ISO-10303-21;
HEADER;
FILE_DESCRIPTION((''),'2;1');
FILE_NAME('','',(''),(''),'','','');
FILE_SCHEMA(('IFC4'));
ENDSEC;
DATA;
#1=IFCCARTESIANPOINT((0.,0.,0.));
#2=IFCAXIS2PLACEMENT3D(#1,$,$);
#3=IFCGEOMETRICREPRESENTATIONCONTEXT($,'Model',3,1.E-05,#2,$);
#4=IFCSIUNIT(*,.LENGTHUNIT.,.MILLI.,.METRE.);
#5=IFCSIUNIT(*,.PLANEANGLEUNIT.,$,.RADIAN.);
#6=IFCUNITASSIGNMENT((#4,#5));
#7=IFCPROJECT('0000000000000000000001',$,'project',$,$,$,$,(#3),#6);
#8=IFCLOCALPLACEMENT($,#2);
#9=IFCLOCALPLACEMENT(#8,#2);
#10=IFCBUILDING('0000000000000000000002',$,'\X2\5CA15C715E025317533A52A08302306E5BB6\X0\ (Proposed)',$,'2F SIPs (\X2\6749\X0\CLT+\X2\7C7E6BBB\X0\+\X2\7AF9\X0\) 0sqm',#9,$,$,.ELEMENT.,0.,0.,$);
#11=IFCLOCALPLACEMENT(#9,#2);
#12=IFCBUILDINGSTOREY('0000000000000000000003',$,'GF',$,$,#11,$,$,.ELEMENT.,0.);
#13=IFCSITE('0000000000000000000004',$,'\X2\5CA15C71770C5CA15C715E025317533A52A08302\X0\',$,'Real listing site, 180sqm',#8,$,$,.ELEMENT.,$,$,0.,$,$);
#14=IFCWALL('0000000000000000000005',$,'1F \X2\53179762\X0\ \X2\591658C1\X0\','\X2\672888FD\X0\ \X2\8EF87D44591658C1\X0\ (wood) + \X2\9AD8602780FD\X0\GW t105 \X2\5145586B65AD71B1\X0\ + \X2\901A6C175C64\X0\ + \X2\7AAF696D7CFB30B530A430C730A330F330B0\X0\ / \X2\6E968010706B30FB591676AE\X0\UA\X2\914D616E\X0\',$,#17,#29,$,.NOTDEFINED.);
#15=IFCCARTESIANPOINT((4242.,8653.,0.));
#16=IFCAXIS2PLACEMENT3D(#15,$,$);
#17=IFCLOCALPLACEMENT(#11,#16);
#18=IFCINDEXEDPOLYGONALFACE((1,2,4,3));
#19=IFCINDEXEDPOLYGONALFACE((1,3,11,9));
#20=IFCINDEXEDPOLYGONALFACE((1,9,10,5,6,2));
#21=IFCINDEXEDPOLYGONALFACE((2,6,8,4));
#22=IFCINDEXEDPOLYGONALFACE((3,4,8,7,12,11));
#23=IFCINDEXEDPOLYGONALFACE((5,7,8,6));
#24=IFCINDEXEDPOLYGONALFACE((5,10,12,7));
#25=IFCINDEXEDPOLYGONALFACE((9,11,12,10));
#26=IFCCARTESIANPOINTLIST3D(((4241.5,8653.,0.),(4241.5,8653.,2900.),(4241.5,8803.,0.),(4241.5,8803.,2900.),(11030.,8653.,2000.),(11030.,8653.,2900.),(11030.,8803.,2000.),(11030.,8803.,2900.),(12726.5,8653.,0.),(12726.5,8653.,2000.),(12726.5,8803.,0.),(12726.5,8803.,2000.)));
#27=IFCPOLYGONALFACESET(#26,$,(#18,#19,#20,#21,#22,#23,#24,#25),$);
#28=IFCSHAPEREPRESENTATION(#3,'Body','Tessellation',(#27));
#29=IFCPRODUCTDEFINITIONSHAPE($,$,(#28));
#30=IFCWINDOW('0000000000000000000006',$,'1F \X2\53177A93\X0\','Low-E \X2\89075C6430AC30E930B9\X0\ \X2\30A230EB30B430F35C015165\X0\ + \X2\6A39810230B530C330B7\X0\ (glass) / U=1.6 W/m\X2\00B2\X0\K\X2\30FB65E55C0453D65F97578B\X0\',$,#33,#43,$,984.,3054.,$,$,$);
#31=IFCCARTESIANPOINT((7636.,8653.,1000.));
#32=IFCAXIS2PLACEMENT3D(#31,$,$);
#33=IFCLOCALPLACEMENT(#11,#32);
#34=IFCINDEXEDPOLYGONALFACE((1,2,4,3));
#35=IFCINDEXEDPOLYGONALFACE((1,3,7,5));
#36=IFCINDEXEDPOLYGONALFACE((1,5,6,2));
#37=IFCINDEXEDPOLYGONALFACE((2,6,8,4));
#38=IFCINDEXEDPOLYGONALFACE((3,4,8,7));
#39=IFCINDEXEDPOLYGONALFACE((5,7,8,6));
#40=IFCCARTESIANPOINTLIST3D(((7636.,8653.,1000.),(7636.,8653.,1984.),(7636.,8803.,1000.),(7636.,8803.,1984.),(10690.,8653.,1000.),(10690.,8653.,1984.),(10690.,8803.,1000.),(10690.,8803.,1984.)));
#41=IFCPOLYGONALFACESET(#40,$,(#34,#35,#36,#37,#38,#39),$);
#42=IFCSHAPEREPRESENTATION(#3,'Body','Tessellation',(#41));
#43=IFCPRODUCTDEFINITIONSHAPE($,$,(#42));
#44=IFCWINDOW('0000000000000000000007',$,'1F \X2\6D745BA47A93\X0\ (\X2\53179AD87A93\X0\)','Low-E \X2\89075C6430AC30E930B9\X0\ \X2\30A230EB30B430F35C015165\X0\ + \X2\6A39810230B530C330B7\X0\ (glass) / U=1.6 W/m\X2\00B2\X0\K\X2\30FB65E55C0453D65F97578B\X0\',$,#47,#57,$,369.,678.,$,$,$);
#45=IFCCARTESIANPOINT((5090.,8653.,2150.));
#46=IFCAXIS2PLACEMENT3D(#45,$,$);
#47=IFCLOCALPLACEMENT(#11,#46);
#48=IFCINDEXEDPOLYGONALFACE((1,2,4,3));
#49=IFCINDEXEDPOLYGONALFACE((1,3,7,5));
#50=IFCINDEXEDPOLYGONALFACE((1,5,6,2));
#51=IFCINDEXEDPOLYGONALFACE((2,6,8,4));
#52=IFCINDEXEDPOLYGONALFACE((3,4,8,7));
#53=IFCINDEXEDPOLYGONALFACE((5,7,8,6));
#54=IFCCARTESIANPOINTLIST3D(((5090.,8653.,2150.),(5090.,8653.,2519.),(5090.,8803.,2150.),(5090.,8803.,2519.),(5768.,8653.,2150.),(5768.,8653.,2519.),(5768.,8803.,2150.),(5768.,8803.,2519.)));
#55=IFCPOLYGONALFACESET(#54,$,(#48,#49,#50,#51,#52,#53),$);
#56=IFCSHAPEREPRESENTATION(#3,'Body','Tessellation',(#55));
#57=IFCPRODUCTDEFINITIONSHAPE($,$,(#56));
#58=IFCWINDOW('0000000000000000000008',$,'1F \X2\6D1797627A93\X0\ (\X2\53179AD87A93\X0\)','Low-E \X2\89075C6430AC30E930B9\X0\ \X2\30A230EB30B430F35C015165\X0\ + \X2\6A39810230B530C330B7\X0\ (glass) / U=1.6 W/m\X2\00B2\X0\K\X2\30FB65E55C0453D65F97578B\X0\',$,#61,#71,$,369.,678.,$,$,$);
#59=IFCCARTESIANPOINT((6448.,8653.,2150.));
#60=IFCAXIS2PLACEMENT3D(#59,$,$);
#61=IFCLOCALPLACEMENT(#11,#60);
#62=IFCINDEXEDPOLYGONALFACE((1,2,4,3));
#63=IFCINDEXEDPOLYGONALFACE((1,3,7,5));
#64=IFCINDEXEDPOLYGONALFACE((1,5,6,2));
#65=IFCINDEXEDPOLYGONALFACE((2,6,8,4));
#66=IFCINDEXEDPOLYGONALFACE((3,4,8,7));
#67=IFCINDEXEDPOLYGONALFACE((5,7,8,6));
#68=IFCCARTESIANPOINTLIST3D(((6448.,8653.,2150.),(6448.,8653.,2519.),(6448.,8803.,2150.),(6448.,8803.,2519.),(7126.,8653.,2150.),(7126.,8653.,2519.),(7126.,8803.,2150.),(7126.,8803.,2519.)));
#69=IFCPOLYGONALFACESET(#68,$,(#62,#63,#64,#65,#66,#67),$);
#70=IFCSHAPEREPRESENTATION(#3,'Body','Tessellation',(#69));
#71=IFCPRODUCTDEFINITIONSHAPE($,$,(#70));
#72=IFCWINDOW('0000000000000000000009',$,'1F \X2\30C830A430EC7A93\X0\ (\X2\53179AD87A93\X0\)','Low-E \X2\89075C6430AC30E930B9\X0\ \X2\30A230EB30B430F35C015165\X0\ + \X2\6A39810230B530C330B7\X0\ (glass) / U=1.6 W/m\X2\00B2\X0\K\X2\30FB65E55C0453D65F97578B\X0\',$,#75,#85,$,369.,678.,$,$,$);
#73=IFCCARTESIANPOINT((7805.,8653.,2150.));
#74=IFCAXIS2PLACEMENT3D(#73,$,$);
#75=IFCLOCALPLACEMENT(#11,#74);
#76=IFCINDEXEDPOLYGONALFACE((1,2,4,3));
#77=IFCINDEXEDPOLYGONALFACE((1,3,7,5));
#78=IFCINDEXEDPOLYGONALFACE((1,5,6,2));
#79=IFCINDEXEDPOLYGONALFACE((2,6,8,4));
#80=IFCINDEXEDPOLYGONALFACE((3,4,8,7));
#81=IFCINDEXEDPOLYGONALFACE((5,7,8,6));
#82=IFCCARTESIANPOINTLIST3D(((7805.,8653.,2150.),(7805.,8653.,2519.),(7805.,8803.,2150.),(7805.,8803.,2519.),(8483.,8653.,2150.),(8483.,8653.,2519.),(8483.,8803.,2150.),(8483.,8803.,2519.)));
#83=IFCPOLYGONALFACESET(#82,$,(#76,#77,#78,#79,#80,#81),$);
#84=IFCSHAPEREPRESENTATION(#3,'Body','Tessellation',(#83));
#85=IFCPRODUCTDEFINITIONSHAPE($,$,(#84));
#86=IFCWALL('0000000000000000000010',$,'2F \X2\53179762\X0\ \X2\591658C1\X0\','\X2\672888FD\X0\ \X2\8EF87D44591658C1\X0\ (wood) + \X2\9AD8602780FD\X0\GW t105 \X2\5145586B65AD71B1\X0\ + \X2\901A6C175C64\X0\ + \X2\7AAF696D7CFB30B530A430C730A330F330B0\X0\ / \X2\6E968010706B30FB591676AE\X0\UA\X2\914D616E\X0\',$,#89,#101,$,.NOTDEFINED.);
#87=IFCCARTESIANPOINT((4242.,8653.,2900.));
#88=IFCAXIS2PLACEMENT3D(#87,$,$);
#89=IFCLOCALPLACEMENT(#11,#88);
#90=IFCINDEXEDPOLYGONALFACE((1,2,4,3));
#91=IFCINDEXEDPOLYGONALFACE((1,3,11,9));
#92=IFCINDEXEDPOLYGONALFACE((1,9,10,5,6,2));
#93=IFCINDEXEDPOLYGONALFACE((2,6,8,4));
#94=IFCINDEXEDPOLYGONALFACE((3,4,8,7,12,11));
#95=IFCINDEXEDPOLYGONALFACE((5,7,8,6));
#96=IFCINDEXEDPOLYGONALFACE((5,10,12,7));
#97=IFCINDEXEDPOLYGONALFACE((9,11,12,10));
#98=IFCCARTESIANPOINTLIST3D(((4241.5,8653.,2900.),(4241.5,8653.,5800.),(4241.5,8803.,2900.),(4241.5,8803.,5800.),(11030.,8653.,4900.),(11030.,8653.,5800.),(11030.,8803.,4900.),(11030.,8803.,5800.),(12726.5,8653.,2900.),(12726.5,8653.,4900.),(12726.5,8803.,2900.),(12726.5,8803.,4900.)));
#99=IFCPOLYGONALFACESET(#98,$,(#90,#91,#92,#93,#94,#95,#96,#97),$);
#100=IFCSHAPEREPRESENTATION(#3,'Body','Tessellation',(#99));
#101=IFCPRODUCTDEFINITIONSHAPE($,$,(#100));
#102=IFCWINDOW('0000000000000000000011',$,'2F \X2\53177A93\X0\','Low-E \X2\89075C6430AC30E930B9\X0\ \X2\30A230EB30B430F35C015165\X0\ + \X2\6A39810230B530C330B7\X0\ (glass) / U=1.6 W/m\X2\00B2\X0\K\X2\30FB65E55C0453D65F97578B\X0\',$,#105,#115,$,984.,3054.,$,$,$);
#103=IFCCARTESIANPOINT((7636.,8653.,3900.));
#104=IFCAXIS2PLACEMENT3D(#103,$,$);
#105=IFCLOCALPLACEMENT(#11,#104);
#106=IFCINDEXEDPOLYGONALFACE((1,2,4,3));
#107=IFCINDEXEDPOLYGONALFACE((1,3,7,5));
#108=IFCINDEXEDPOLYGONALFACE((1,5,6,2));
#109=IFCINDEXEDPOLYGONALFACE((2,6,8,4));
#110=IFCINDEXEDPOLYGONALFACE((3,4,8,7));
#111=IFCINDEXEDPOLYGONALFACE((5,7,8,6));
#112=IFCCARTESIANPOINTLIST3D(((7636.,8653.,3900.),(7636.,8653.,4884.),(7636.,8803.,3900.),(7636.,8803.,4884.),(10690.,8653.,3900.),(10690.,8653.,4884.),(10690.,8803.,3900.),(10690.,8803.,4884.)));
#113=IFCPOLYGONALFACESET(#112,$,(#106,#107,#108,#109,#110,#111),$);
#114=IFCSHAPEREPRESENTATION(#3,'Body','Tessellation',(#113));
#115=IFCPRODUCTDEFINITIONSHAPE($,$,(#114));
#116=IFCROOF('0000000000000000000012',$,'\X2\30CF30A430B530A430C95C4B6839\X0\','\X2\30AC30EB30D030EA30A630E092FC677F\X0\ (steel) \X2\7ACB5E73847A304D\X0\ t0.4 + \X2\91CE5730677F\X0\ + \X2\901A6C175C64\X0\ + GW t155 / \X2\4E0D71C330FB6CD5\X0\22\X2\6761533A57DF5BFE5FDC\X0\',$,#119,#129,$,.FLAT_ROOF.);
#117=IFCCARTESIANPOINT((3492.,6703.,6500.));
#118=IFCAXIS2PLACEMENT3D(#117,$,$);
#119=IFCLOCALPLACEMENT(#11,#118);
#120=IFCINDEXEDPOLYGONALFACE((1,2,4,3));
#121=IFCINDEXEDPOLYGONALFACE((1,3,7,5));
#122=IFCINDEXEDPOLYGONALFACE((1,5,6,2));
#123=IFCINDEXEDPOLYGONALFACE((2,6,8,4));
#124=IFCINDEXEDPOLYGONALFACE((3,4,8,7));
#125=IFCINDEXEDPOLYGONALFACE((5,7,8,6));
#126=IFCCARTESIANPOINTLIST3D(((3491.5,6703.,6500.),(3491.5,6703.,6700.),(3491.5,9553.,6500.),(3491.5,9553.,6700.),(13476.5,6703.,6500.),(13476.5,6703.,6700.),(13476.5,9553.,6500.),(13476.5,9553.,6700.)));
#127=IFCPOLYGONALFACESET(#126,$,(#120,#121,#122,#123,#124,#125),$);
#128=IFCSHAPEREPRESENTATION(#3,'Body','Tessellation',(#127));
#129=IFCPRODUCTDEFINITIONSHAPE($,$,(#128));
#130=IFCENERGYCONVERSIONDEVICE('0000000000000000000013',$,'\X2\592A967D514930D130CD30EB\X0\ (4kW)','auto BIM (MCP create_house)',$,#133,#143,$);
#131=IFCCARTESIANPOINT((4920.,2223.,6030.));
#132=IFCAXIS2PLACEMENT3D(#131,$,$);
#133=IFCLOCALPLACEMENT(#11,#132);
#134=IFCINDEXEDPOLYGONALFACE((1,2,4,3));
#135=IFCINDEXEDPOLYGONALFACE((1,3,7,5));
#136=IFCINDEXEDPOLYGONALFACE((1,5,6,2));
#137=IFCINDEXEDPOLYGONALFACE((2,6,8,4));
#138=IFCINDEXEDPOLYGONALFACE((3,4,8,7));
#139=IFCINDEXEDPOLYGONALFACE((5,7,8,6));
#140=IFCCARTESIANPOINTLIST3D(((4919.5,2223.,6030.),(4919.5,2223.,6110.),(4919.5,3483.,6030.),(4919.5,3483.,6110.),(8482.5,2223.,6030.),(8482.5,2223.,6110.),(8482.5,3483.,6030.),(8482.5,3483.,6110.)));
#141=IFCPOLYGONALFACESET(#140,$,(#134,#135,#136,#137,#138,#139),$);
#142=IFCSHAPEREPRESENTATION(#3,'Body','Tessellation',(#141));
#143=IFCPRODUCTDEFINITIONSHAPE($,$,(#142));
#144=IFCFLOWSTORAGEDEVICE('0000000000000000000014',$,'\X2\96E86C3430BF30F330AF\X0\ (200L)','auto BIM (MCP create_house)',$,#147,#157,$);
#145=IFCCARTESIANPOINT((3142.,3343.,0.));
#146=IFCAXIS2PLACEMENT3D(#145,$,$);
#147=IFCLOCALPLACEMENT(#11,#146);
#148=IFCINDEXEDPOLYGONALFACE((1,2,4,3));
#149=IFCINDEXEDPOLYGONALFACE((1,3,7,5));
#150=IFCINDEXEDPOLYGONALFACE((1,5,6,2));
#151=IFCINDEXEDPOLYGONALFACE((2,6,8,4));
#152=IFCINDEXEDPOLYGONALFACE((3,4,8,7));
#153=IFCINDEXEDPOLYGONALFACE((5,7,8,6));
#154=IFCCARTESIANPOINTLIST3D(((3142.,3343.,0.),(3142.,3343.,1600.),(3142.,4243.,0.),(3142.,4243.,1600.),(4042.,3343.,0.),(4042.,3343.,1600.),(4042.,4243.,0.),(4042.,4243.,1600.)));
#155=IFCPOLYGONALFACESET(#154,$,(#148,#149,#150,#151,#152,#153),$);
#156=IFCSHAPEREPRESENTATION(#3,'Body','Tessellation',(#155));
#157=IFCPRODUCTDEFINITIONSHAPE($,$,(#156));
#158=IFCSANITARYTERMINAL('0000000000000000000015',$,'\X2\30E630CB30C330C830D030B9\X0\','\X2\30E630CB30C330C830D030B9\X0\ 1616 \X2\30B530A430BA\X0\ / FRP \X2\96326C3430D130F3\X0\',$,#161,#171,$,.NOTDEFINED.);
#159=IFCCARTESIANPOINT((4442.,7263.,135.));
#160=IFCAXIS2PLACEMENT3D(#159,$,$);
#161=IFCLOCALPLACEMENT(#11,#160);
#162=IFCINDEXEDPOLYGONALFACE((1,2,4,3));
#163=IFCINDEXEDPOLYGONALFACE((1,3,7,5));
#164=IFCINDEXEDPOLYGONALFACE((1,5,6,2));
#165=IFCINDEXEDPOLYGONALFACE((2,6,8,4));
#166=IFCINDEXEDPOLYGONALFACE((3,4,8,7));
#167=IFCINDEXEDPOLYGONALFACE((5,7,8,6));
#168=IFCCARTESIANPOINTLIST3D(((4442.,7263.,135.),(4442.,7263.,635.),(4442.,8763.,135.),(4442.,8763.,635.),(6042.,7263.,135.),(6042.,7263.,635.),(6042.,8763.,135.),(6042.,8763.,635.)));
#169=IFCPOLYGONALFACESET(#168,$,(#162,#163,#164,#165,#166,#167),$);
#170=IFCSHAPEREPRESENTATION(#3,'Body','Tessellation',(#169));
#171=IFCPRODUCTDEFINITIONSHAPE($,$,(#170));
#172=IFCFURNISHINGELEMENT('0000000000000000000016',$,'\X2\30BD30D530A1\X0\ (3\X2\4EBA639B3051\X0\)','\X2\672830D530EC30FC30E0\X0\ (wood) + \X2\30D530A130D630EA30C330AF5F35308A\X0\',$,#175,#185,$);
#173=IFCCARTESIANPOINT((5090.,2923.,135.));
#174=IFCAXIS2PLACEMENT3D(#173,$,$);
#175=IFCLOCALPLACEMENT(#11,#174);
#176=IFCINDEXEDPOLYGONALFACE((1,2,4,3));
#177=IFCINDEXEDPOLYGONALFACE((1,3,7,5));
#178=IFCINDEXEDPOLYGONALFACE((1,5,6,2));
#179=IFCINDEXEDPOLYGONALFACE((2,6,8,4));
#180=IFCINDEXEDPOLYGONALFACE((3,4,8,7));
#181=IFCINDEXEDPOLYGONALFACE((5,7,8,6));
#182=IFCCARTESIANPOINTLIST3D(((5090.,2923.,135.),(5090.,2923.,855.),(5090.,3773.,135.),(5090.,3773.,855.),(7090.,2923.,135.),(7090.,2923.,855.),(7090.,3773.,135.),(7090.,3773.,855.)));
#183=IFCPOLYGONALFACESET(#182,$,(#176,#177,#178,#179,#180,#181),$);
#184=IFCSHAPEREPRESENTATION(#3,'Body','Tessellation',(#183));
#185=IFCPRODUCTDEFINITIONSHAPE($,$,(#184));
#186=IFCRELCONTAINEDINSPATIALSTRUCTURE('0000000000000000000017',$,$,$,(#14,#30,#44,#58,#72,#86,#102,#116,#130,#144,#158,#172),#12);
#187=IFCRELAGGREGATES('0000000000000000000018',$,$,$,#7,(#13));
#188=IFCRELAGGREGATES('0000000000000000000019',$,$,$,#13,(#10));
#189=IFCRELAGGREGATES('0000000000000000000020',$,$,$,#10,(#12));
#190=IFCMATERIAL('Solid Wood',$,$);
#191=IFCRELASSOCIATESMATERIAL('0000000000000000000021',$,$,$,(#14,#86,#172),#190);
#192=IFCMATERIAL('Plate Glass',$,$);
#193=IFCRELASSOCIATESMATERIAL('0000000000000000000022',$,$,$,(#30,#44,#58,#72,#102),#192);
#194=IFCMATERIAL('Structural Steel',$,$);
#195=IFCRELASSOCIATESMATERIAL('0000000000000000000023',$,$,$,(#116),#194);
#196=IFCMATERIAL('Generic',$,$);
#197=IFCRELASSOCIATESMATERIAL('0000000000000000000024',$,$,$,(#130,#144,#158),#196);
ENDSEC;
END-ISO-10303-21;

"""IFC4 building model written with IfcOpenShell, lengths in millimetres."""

from ifc_helpers import new_model, si_unit, frame, frame_2d, origin, place, context, project, spatial, rectangle, extrude, material, element, fill, save


model = new_model("IFC4")

# Units and contexts
model_context = context("Model", 3, precision=1e-05, world=origin())
ifc_project = project(units=[si_unit("LENGTHUNIT", "METRE", prefix="MILLI"), si_unit("PLANEANGLEUNIT", "RADIAN")], contexts=[model_context])

# Site, building, storey
site_placement = place(None, origin())
site = spatial("IfcSite", under=ifc_project, at=site_placement, Name="岡山県岡山市北区加茂", ObjectType="Real listing site, 180sqm", CompositionType="ELEMENT", RefElevation=0.0)
building_placement = place(site_placement, origin())
building = spatial("IfcBuilding", under=site, at=building_placement, Name="岡山市北区加茂の家 (Proposed)", ObjectType="2F SIPs (杉CLT+籾殻+竹) 0sqm", CompositionType="ELEMENT", ElevationOfRefHeight=0.0, ElevationOfTerrain=0.0)
storey_placement = place(building_placement, origin())
storey = spatial("IfcBuildingStorey", under=building, at=storey_placement, Name="GF", CompositionType="ELEMENT", Elevation=0.0)

# Wall, openings, windows
ifc_material_1 = material(Name="Solid Wood")
wall_1_placement = place(storey_placement, frame((4242.0, 8653.0, 0.0)))
wall_1 = element("IfcWall", 1, at=wall_1_placement, inside=storey, material=ifc_material_1, Name="1F 北面 外壁", Description="木製 軸組外壁 (wood) + 高性能GW t105 充填断熱 + 通気層 + 窯業系サイディング / 準耐火・外皮UA配慮", PredefinedType="NOTDEFINED", context=model_context, shape_type="SweptSolid", body=[
    extrude(rectangle(XDim=8485.0, YDim=150.0, at=frame_2d((4242.0, 75.0))), frame((4242.0, 8653.0, 0.0)), (0.0, 0.0, 1.0), 2900.0),
])
opening_1_placement = place(storey_placement, frame((7636.0, 8653.0, 1000.0)))
opening_1 = element("IfcOpeningElement", 2, at=opening_1_placement, cuts=wall_1, PredefinedType="NOTDEFINED", context=model_context, shape_type="SweptSolid", body=[
    extrude(rectangle(XDim=3054.0, YDim=150.0, at=frame_2d((1527.0, 75.0))), frame((7636.0, 8653.0, 1000.0)), (0.0, 0.0, 1.0), 984.0),
])
opening_2_placement = place(storey_placement, frame((5090.0, 8653.0, 2150.0)))
opening_2 = element("IfcOpeningElement", 3, at=opening_2_placement, cuts=wall_1, PredefinedType="NOTDEFINED", context=model_context, shape_type="SweptSolid", body=[
    extrude(rectangle(XDim=678.0, YDim=150.0, at=frame_2d((339.0, 75.0))), frame((5090.0, 8653.0, 2150.0)), (0.0, 0.0, 1.0), 369.0),
])
opening_3_placement = place(storey_placement, frame((6448.0, 8653.0, 2150.0)))
opening_3 = element("IfcOpeningElement", 4, at=opening_3_placement, cuts=wall_1, PredefinedType="NOTDEFINED", context=model_context, shape_type="SweptSolid", body=[
    extrude(rectangle(XDim=678.0, YDim=150.0, at=frame_2d((339.0, 75.0))), frame((6448.0, 8653.0, 2150.0)), (0.0, 0.0, 1.0), 369.0),
])
opening_4_placement = place(storey_placement, frame((7805.0, 8653.0, 2150.0)))
opening_4 = element("IfcOpeningElement", 5, at=opening_4_placement, cuts=wall_1, PredefinedType="NOTDEFINED", context=model_context, shape_type="SweptSolid", body=[
    extrude(rectangle(XDim=678.0, YDim=150.0, at=frame_2d((339.0, 75.0))), frame((7805.0, 8653.0, 2150.0)), (0.0, 0.0, 1.0), 369.0),
])
ifc_material_2 = material(Name="Plate Glass")
window_1_placement = place(storey_placement, frame((7636.0, 8653.0, 1000.0)))
window_1 = element("IfcWindow", 6, at=window_1_placement, inside=storey, material=ifc_material_2, Name="1F 北窓", Description="Low-E 複層ガラス アルゴン封入 + 樹脂サッシ (glass) / U=1.6 W/m²K・日射取得型", OverallHeight=984.0, OverallWidth=3054.0, context=model_context, shape_type="SweptSolid", body=[
    extrude(rectangle(XDim=3054.0, YDim=150.0, at=frame_2d((1527.0, 75.0))), frame((7636.0, 8653.0, 1000.0)), (0.0, 0.0, 1.0), 984.0),
])
fill(opening_1, window_1)
window_2_placement = place(storey_placement, frame((5090.0, 8653.0, 2150.0)))
window_2 = element("IfcWindow", 7, at=window_2_placement, inside=storey, material=ifc_material_2, Name="1F 浴室窓 (北高窓)", Description="Low-E 複層ガラス アルゴン封入 + 樹脂サッシ (glass) / U=1.6 W/m²K・日射取得型", OverallHeight=369.0, OverallWidth=678.0, context=model_context, shape_type="SweptSolid", body=[
    extrude(rectangle(XDim=678.0, YDim=150.0, at=frame_2d((339.0, 75.0))), frame((5090.0, 8653.0, 2150.0)), (0.0, 0.0, 1.0), 369.0),
])
fill(opening_2, window_2)
window_3_placement = place(storey_placement, frame((6448.0, 8653.0, 2150.0)))
window_3 = element("IfcWindow", 8, at=window_3_placement, inside=storey, material=ifc_material_2, Name="1F 洗面窓 (北高窓)", Description="Low-E 複層ガラス アルゴン封入 + 樹脂サッシ (glass) / U=1.6 W/m²K・日射取得型", OverallHeight=369.0, OverallWidth=678.0, context=model_context, shape_type="SweptSolid", body=[
    extrude(rectangle(XDim=678.0, YDim=150.0, at=frame_2d((339.0, 75.0))), frame((6448.0, 8653.0, 2150.0)), (0.0, 0.0, 1.0), 369.0),
])
fill(opening_3, window_3)
window_4_placement = place(storey_placement, frame((7805.0, 8653.0, 2150.0)))
window_4 = element("IfcWindow", 9, at=window_4_placement, inside=storey, material=ifc_material_2, Name="1F トイレ窓 (北高窓)", Description="Low-E 複層ガラス アルゴン封入 + 樹脂サッシ (glass) / U=1.6 W/m²K・日射取得型", OverallHeight=369.0, OverallWidth=678.0, context=model_context, shape_type="SweptSolid", body=[
    extrude(rectangle(XDim=678.0, YDim=150.0, at=frame_2d((339.0, 75.0))), frame((7805.0, 8653.0, 2150.0)), (0.0, 0.0, 1.0), 369.0),
])
fill(opening_4, window_4)

# Wall, opening, window
wall_2_placement = place(storey_placement, frame((4242.0, 8653.0, 2900.0)))
wall_2 = element("IfcWall", 10, at=wall_2_placement, inside=storey, material=ifc_material_1, Name="2F 北面 外壁", Description="木製 軸組外壁 (wood) + 高性能GW t105 充填断熱 + 通気層 + 窯業系サイディング / 準耐火・外皮UA配慮", PredefinedType="NOTDEFINED", context=model_context, shape_type="SweptSolid", body=[
    extrude(rectangle(XDim=8485.0, YDim=150.0, at=frame_2d((4242.0, 75.0))), frame((4242.0, 8653.0, 2900.0)), (0.0, 0.0, 1.0), 2900.0),
])
opening_5_placement = place(storey_placement, frame((7636.0, 8653.0, 3900.0)))
opening_5 = element("IfcOpeningElement", 11, at=opening_5_placement, cuts=wall_2, PredefinedType="NOTDEFINED", context=model_context, shape_type="SweptSolid", body=[
    extrude(rectangle(XDim=3054.0, YDim=150.0, at=frame_2d((1527.0, 75.0))), frame((7636.0, 8653.0, 3900.0)), (0.0, 0.0, 1.0), 984.0),
])
window_5_placement = place(storey_placement, frame((7636.0, 8653.0, 3900.0)))
window_5 = element("IfcWindow", 12, at=window_5_placement, inside=storey, material=ifc_material_2, Name="2F 北窓", Description="Low-E 複層ガラス アルゴン封入 + 樹脂サッシ (glass) / U=1.6 W/m²K・日射取得型", OverallHeight=984.0, OverallWidth=3054.0, context=model_context, shape_type="SweptSolid", body=[
    extrude(rectangle(XDim=3054.0, YDim=150.0, at=frame_2d((1527.0, 75.0))), frame((7636.0, 8653.0, 3900.0)), (0.0, 0.0, 1.0), 984.0),
])
fill(opening_5, window_5)

# Roof
ifc_material_3 = material(Name="Structural Steel")
roof_placement = place(storey_placement, frame((3492.0, 6703.0, 6500.0)))
element("IfcRoof", 13, at=roof_placement, inside=storey, material=ifc_material_3, Name="ハイサイド屋根", Description="ガルバリウム鋼板 (steel) 立平葺き t0.4 + 野地板 + 通気層 + GW t155 / 不燃・法22条区域対応", PredefinedType="FLAT_ROOF", context=model_context, shape_type="SweptSolid", body=[
    extrude(rectangle(XDim=9985.0, YDim=2850.0, at=frame_2d((4992.0, 1425.0))), frame((3492.0, 6703.0, 6500.0)), (0.0, 0.0, 1.0), 200.0),
])

# Energy conversion device
ifc_material_4 = material(Name="Generic")
energy_conversion_device_placement = place(storey_placement, frame((4920.0, 2223.0, 6030.0)))
element("IfcEnergyConversionDevice", 14, at=energy_conversion_device_placement, inside=storey, material=ifc_material_4, Name="太陽光パネル (4kW)", Description="auto BIM (MCP create_house)", context=model_context, shape_type="SweptSolid", body=[
    extrude(rectangle(XDim=3563.0, YDim=1260.0, at=frame_2d((1781.0, 630.0))), frame((4920.0, 2223.0, 6030.0)), (0.0, 0.0, 1.0), 80.0),
])

# Flow storage device
flow_storage_device_placement = place(storey_placement, frame((3142.0, 3343.0, 0.0)))
element("IfcFlowStorageDevice", 15, at=flow_storage_device_placement, inside=storey, material=ifc_material_4, Name="雨水タンク (200L)", Description="auto BIM (MCP create_house)", context=model_context, shape_type="SweptSolid", body=[
    extrude(rectangle(XDim=900.0, YDim=900.0, at=frame_2d((450.0, 450.0))), frame((3142.0, 3343.0, 0.0)), (0.0, 0.0, 1.0), 1600.0),
])

# Sanitary terminal
sanitary_terminal_placement = place(storey_placement, frame((4442.0, 7263.0, 135.0)))
element("IfcSanitaryTerminal", 16, at=sanitary_terminal_placement, inside=storey, material=ifc_material_4, Name="ユニットバス", Description="ユニットバス 1616 サイズ / FRP 防水パン", PredefinedType="NOTDEFINED", context=model_context, shape_type="SweptSolid", body=[
    extrude(rectangle(XDim=1600.0, YDim=1500.0, at=frame_2d((800.0, 750.0))), frame((4442.0, 7263.0, 135.0)), (0.0, 0.0, 1.0), 500.0),
])

# Furnishing element
furnishing_1_placement = place(storey_placement, frame((5090.0, 2923.0, 135.0)))
element("IfcFurnishingElement", 17, at=furnishing_1_placement, inside=storey, material=ifc_material_1, Name="ソファ (3人掛け)", Description="木フレーム (wood) + ファブリック張り", context=model_context, shape_type="SweptSolid", body=[
    extrude(rectangle(XDim=2000.0, YDim=850.0, at=frame_2d((1000.0, 425.0))), frame((5090.0, 2923.0, 135.0)), (0.0, 0.0, 1.0), 720.0),
])

save(model, "model.ifc")
